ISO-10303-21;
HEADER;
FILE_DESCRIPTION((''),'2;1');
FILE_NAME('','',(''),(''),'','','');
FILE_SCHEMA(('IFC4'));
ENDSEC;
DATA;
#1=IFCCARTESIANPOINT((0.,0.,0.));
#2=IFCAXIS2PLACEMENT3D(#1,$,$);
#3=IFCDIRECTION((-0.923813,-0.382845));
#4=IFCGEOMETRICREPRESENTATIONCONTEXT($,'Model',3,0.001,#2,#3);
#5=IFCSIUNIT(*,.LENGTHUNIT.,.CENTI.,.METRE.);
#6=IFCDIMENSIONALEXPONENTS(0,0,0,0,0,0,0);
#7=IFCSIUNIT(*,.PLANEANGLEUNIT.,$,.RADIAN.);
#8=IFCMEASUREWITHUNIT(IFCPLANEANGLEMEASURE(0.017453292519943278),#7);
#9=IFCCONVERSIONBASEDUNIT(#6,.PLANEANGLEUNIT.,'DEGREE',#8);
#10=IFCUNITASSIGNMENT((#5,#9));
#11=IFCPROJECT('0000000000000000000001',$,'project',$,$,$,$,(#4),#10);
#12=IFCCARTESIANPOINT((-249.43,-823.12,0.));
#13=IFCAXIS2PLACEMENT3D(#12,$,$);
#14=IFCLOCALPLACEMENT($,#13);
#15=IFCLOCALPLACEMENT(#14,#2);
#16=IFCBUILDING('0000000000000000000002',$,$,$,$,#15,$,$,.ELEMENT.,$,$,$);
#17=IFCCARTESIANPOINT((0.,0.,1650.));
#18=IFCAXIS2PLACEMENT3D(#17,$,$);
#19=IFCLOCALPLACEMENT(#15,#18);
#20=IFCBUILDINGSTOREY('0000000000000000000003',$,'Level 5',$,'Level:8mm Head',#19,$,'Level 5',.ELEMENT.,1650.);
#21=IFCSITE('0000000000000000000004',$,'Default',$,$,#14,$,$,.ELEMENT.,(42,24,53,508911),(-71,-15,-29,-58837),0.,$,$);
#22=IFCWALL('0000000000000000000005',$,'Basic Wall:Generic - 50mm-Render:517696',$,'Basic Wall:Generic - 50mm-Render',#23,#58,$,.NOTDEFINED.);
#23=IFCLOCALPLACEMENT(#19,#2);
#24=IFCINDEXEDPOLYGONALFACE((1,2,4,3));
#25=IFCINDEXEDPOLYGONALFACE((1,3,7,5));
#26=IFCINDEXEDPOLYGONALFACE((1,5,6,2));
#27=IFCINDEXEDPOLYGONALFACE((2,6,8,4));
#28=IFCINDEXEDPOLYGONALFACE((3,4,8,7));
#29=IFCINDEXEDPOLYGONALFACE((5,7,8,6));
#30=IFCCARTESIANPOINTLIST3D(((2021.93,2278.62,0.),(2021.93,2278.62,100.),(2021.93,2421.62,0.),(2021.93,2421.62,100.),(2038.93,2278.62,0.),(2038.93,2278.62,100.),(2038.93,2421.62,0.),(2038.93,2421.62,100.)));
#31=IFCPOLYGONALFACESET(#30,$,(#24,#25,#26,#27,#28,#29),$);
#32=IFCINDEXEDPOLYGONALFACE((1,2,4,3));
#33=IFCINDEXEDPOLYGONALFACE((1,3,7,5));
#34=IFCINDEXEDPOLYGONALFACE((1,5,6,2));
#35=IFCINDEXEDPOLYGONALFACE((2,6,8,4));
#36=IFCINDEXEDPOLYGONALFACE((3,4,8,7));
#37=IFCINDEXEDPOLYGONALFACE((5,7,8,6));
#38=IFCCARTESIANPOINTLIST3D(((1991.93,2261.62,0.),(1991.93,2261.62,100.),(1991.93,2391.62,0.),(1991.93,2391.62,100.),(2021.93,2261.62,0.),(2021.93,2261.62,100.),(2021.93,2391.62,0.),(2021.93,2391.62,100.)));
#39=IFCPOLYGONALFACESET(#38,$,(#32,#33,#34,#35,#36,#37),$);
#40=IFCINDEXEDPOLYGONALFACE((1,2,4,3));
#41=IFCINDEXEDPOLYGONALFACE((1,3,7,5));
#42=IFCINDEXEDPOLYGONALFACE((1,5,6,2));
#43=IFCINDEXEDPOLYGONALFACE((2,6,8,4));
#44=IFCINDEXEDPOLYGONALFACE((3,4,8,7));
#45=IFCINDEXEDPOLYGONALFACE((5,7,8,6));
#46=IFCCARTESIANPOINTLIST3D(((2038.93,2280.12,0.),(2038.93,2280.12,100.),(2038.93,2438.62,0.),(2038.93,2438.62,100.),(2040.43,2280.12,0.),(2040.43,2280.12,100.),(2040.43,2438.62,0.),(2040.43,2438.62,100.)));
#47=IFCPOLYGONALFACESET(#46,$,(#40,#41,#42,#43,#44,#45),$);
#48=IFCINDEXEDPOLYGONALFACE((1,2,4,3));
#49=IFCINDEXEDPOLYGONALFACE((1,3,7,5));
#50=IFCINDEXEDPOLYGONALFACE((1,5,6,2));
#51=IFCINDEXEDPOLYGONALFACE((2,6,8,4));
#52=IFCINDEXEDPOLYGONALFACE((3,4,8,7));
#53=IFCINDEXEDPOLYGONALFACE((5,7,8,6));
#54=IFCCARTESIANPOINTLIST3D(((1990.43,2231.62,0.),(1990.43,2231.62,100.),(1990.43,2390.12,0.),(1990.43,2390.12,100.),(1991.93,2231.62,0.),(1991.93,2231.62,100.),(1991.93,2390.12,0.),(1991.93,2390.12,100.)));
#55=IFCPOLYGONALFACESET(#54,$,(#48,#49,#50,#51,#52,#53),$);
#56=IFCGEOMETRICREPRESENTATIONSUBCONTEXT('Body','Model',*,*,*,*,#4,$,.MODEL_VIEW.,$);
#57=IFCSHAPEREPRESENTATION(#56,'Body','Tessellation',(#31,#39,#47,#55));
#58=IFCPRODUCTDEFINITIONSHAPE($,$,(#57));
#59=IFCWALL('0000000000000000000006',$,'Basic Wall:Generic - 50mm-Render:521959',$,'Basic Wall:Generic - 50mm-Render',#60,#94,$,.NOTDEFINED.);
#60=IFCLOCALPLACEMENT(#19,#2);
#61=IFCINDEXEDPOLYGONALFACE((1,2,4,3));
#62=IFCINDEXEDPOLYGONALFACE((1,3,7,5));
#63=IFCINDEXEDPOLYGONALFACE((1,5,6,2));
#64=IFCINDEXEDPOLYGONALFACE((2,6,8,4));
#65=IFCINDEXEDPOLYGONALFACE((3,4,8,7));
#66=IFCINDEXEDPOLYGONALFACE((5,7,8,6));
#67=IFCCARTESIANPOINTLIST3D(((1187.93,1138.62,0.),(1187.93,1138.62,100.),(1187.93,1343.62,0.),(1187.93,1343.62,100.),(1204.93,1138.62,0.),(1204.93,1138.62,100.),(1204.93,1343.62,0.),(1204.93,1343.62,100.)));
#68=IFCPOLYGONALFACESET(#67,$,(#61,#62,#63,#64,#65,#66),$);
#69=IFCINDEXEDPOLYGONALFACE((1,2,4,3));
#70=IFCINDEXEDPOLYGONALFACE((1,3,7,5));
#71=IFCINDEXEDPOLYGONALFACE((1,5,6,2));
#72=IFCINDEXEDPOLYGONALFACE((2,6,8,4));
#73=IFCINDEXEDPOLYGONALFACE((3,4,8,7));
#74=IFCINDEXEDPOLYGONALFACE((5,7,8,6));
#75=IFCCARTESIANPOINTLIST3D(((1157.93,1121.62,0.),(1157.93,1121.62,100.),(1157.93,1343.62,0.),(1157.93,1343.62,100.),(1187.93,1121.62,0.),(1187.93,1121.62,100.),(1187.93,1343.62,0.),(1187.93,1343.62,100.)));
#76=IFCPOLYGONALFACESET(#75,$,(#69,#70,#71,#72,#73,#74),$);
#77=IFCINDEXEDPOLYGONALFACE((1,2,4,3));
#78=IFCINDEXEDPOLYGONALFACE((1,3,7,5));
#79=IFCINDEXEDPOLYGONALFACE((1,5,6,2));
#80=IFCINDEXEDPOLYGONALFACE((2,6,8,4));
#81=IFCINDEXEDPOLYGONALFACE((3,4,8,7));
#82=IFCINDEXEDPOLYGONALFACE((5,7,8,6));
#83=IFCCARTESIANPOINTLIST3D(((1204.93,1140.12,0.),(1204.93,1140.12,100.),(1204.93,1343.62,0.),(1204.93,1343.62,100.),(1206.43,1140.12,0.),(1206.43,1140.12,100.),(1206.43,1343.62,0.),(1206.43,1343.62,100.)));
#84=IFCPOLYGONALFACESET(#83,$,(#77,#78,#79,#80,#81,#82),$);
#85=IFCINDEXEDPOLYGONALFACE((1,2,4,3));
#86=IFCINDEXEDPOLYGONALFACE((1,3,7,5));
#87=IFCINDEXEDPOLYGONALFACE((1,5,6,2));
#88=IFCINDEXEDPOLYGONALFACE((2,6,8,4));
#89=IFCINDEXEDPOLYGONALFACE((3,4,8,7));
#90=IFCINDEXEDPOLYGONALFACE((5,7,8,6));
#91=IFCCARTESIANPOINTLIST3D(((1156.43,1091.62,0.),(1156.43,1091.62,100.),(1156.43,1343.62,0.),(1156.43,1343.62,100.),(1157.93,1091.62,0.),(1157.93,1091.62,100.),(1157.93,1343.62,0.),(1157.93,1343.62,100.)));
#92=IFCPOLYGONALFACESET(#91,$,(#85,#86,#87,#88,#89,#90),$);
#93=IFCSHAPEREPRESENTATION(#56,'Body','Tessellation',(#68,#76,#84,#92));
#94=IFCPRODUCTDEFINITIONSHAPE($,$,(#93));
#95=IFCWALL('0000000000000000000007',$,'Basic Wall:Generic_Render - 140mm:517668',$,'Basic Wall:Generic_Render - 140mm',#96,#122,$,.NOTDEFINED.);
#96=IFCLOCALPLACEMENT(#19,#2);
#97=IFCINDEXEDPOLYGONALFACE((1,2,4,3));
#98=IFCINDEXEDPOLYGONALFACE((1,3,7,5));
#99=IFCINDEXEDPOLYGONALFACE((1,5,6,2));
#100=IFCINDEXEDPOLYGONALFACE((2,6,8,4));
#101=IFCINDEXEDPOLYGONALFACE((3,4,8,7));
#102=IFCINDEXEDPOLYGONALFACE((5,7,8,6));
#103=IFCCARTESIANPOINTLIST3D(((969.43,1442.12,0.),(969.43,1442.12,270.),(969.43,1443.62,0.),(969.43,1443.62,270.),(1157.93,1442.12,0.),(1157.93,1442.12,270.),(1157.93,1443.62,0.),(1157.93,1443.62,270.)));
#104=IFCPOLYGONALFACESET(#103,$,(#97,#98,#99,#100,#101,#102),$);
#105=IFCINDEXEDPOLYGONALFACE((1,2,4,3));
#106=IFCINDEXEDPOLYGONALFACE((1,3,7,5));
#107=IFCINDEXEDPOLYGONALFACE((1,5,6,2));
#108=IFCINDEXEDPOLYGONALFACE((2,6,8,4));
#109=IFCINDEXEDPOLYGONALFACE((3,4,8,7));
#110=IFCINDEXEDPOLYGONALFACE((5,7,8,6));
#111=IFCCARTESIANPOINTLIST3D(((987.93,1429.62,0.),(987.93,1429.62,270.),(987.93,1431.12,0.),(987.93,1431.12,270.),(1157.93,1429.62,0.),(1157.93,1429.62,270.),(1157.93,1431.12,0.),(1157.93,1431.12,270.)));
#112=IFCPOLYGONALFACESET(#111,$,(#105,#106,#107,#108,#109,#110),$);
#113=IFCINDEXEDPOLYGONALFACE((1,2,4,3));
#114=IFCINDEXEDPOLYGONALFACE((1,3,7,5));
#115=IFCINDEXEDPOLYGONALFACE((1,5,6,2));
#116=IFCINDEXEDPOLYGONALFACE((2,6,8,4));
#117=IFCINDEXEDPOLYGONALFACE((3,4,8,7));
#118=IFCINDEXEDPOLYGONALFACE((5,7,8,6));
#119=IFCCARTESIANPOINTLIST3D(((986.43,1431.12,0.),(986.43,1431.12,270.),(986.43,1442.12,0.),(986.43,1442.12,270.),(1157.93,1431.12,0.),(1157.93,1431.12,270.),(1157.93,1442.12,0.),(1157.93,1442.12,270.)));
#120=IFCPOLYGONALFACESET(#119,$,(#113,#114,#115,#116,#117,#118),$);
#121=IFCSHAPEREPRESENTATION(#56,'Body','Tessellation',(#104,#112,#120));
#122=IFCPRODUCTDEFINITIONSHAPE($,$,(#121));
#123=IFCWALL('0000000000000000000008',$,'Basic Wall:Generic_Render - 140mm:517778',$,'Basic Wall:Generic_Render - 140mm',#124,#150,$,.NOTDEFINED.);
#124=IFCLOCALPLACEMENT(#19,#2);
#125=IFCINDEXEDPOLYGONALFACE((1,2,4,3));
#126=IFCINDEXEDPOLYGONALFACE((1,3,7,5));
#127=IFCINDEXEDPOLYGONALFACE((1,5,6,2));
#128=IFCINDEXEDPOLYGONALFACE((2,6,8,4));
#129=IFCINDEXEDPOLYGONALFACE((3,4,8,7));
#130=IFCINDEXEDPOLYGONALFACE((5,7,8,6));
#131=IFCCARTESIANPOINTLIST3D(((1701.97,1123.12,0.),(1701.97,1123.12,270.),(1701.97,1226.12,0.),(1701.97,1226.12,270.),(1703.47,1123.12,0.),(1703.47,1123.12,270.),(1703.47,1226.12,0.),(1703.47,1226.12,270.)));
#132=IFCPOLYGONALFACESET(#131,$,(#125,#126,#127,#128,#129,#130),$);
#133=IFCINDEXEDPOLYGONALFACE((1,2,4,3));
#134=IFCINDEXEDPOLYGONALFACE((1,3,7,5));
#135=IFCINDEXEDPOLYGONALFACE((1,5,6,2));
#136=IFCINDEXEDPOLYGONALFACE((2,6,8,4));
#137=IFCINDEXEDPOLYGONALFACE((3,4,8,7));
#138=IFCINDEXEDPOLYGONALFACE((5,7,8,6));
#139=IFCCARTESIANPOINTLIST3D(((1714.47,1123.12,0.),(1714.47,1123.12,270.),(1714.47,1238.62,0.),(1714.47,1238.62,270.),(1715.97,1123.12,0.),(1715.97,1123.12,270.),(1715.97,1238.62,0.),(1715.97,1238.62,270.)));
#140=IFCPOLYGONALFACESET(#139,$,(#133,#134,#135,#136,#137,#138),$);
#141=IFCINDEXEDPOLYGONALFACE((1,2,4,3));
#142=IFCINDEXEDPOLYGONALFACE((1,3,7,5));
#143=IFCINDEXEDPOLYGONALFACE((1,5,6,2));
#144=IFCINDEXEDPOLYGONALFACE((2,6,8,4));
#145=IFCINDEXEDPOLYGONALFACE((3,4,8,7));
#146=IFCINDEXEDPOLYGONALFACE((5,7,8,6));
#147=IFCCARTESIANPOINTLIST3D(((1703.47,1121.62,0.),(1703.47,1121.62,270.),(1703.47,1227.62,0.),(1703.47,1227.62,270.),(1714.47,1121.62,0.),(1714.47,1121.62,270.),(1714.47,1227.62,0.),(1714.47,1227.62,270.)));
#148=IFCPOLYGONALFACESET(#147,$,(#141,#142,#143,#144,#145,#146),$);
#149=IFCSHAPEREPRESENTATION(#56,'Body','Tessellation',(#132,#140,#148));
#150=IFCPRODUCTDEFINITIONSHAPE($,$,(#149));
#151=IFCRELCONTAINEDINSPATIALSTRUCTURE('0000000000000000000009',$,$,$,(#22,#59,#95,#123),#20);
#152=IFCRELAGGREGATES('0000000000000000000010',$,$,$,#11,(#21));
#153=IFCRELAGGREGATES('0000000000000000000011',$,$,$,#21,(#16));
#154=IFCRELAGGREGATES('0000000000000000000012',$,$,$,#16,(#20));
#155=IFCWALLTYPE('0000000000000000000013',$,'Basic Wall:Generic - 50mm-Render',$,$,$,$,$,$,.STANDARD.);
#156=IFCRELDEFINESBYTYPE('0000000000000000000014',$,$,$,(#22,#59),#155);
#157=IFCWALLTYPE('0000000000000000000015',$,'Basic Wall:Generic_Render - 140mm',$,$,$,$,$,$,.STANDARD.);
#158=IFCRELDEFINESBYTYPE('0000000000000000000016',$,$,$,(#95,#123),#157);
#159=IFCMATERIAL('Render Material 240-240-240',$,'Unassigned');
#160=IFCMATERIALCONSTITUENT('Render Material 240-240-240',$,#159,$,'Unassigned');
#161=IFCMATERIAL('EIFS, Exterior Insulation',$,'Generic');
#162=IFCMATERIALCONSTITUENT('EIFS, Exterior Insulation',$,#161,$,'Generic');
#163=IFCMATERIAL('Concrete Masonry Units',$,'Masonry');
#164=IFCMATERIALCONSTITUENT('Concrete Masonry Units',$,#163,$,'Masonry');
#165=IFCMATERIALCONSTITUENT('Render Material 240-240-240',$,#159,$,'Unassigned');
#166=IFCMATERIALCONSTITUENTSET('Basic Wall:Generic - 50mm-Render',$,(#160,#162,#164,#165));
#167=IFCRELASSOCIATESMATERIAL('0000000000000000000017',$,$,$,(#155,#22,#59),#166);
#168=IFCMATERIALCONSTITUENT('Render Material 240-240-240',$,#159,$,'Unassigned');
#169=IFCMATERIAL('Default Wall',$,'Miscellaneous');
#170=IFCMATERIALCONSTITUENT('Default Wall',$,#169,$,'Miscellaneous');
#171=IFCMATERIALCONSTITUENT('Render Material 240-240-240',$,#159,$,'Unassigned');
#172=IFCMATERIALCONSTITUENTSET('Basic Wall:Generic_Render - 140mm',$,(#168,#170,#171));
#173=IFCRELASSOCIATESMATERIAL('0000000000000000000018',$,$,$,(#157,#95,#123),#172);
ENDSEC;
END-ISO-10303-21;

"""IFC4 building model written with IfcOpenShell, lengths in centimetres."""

from ifc_helpers import new_model, entity, si_unit, converted_unit, direction, frame, origin, place, context, subcontext, project, spatial, indexed_curve, outline, extrude, material, constituent, constituent_set, type_object, element, save


model = new_model("IFC4")

# Units and contexts
model_context = context("Model", 3, precision=0.001, world=origin(), true_north=direction((-0.923813, -0.382845)))
body_context = subcontext(model_context, "Body", "Model", "MODEL_VIEW")
ifc_project = project(units=[si_unit("LENGTHUNIT", "METRE", prefix="CENTI"), converted_unit("PLANEANGLEUNIT", "DEGREE", entity("IfcPlaneAngleMeasure", 0.017453292519943278), si_unit("PLANEANGLEUNIT", "RADIAN"), dimensions=[0, 0, 0, 0, 0, 0, 0])], contexts=[model_context])

# Site, building, storey
site_placement = place(None, frame((-249.43, -823.12, 0.0)))
site = spatial("IfcSite", under=ifc_project, at=site_placement, Name="Default", CompositionType="ELEMENT", RefLatitude=(42, 24, 53, 508911), RefLongitude=(-71, -15, -29, -58837), RefElevation=0.0)
building_placement = place(site_placement, origin())
building = spatial("IfcBuilding", under=site, at=building_placement, CompositionType="ELEMENT")
storey_placement = place(building_placement, frame((0.0, 0.0, 1650.0)))
storey = spatial("IfcBuildingStorey", under=building, at=storey_placement, Name="Level 5", ObjectType="Level:8mm Head", LongName="Level 5", CompositionType="ELEMENT", Elevation=1650.0)

# Walls
ifc_material_1 = material(Name="Concrete Masonry Units", Category="Masonry")
ifc_material_2 = material(Name="Render Material 240-240-240", Category="Unassigned")
ifc_constituent_1 = constituent(ifc_material_2, Name="Render Material 240-240-240", Category="Unassigned")
ifc_material_3 = material(Name="EIFS, Exterior Insulation", Category="Generic")
ifc_constituent_2 = constituent(ifc_material_3, Name="EIFS, Exterior Insulation", Category="Generic")
ifc_constituent_3 = constituent(ifc_material_1, Name="Concrete Masonry Units", Category="Masonry")
ifc_constituent_4 = constituent(ifc_material_2, Name="Render Material 240-240-240", Category="Unassigned")
ifc_constituent_set_1 = constituent_set(constituents=[ifc_constituent_1, ifc_constituent_2, ifc_constituent_3, ifc_constituent_4], Name="Basic Wall:Generic - 50mm-Render")
wall_type_1 = type_object("IfcWallType", Name="Basic Wall:Generic - 50mm-Render", PredefinedType="STANDARD", material=ifc_constituent_set_1)
wall_1_placement = place(storey_placement, frame((2015.43, 2280.12, 0.0), z_axis=(0.0, 0.0, 1.0), x_axis=(0.0, 1.0, 0.0)))
element("IfcWall", 1, at=wall_1_placement, inside=storey, type_object=wall_type_1, material=ifc_constituent_set_1, Name="Basic Wall:Generic - 50mm-Render:517696", ObjectType="Basic Wall:Generic - 50mm-Render", PredefinedType="NOTDEFINED", context=body_context, shape_type="SweptSolid", body=[
    extrude(outline(indexed_curve([(-71.5, -8.5), (71.5, -8.5), (71.5, 8.5), (-71.5, 8.5), (-71.5, -8.5)], self_intersect=False)), frame((70.0, -15.0, 0.0)), (0.0, 0.0, 1.0), 100.0),
    extrude(outline(indexed_curve([(-65.0, -15.0), (65.0, -15.0), (65.0, 15.0), (-65.0, 15.0), (-65.0, -15.0)], self_intersect=False)), frame((46.5, 8.5, 0.0)), (0.0, 0.0, 1.0), 100.0),
    extrude(outline(indexed_curve([(-0.75, -79.25), (0.75, -79.25), (0.75, 79.25), (-0.75, 79.25), (-0.75, -79.25)], self_intersect=False)), frame((79.25, -24.25, 0.0), z_axis=(0.0, 0.0, 1.0), x_axis=(0.0, 1.0, 0.0)), (0.0, 0.0, 1.0), 100.0),
    extrude(outline(indexed_curve([(-0.75, -79.25), (0.75, -79.25), (0.75, 79.25), (-0.75, 79.25), (-0.75, -79.25)], self_intersect=False)), frame((30.75, 24.25, 0.0), z_axis=(0.0, 0.0, 1.0), x_axis=(0.0, -1.0, 0.0)), (0.0, 0.0, 1.0), 100.0),
])
wall_2_placement = place(storey_placement, frame((1181.43, 1343.62, 0.0), z_axis=(0.0, 0.0, 1.0), x_axis=(0.0, -1.0, 0.0)))
element("IfcWall", 2, at=wall_2_placement, inside=storey, type_object=wall_type_1, material=ifc_constituent_set_1, Name="Basic Wall:Generic - 50mm-Render:521959", ObjectType="Basic Wall:Generic - 50mm-Render", PredefinedType="NOTDEFINED", context=body_context, shape_type="SweptSolid", body=[
    extrude(outline(indexed_curve([(-102.5, -8.5), (102.5, -8.5), (102.5, 8.5), (-102.5, 8.5), (-102.5, -8.5)], self_intersect=False)), frame((102.5, 15.0, 0.0)), (0.0, 0.0, 1.0), 100.0),
    extrude(outline(indexed_curve([(-111.0, -15.0), (111.0, -15.0), (111.0, 15.0), (-111.0, 15.0), (-111.0, -15.0)], self_intersect=False)), frame((111.0, -8.5, 0.0)), (0.0, 0.0, 1.0), 100.0),
    extrude(outline(indexed_curve([(-0.75, -101.75), (0.75, -101.75), (0.75, 101.75), (-0.75, 101.75), (-0.75, -101.75)], self_intersect=False)), frame((101.75, 24.25, 0.0), z_axis=(0.0, 0.0, 1.0), x_axis=(0.0, -1.0, 0.0)), (0.0, 0.0, 1.0), 100.0),
    extrude(outline(indexed_curve([(-0.75, -126.0), (0.75, -126.0), (0.75, 126.0), (-0.75, 126.0), (-0.75, -126.0)], self_intersect=False)), frame((126.0, -24.25, 0.0), z_axis=(0.0, 0.0, 1.0), x_axis=(0.0, 1.0, 0.0)), (0.0, 0.0, 1.0), 100.0),
])
ifc_material_4 = material(Name="Default Wall", Category="Miscellaneous")
ifc_constituent_5 = constituent(ifc_material_2, Name="Render Material 240-240-240", Category="Unassigned")
ifc_constituent_6 = constituent(ifc_material_4, Name="Default Wall", Category="Miscellaneous")
ifc_constituent_7 = constituent(ifc_material_2, Name="Render Material 240-240-240", Category="Unassigned")
ifc_constituent_set_2 = constituent_set(constituents=[ifc_constituent_5, ifc_constituent_6, ifc_constituent_7], Name="Basic Wall:Generic_Render - 140mm")
wall_type_2 = type_object("IfcWallType", Name="Basic Wall:Generic_Render - 140mm", PredefinedType="STANDARD", material=ifc_constituent_set_2)
wall_3_placement = place(storey_placement, frame((1157.93, 1436.62, 0.0), z_axis=(0.0, 0.0, 1.0), x_axis=(-1.0, 0.0, 0.0)))
element("IfcWall", 3, at=wall_3_placement, inside=storey, type_object=wall_type_2, material=ifc_constituent_set_2, Name="Basic Wall:Generic_Render - 140mm:517668", ObjectType="Basic Wall:Generic_Render - 140mm", PredefinedType="NOTDEFINED", context=body_context, shape_type="SweptSolid", body=[
    extrude(outline(indexed_curve([(-0.75, -94.25), (0.75, -94.25), (0.75, 94.25), (-0.75, 94.25), (-0.75, -94.25)], self_intersect=False)), frame((94.25, -6.25, 0.0), z_axis=(0.0, 0.0, 1.0), x_axis=(0.0, 1.0, 0.0)), (0.0, 0.0, 1.0), 270.0),
    extrude(outline(indexed_curve([(-0.75, -85.0), (0.75, -85.0), (0.75, 85.0), (-0.75, 85.0), (-0.75, -85.0)], self_intersect=False)), frame((85.0, 6.25, 0.0), z_axis=(0.0, 0.0, 1.0), x_axis=(0.0, -1.0, 0.0)), (0.0, 0.0, 1.0), 270.0),
    extrude(outline(indexed_curve([(-85.75, -5.5), (85.75, -5.5), (85.75, 5.5), (-85.75, 5.5), (-85.75, -5.5)], self_intersect=False)), frame((85.75, 0.0, 0.0)), (0.0, 0.0, 1.0), 270.0),
])
wall_4_placement = place(storey_placement, frame((1708.97, 1226.12, 0.0), z_axis=(0.0, 0.0, 1.0), x_axis=(0.0, -1.0, 0.0)))
element("IfcWall", 4, at=wall_4_placement, inside=storey, type_object=wall_type_2, material=ifc_constituent_set_2, Name="Basic Wall:Generic_Render - 140mm:517778", ObjectType="Basic Wall:Generic_Render - 140mm", PredefinedType="NOTDEFINED", context=body_context, shape_type="SweptSolid", body=[
    extrude(outline(indexed_curve([(-0.75, -51.5), (0.75, -51.5), (0.75, 51.5), (-0.75, 51.5), (-0.75, -51.5)], self_intersect=False)), frame((51.5, -6.25, 0.0), z_axis=(0.0, 0.0, 1.0), x_axis=(0.0, 1.0, 0.0)), (0.0, 0.0, 1.0), 270.0),
    extrude(outline(indexed_curve([(-0.75, -57.75), (0.75, -57.75), (0.75, 57.75), (-0.75, 57.75), (-0.75, -57.75)], self_intersect=False)), frame((45.25, 6.25, 0.0), z_axis=(0.0, 0.0, 1.0), x_axis=(0.0, -1.0, 0.0)), (0.0, 0.0, 1.0), 270.0),
    extrude(outline(indexed_curve([(-53.0, -5.5), (53.0, -5.5), (53.0, 5.5), (-53.0, 5.5), (-53.0, -5.5)], self_intersect=False)), frame((51.5, 0.0, 0.0)), (0.0, 0.0, 1.0), 270.0),
])

save(model, "model.ifc")
